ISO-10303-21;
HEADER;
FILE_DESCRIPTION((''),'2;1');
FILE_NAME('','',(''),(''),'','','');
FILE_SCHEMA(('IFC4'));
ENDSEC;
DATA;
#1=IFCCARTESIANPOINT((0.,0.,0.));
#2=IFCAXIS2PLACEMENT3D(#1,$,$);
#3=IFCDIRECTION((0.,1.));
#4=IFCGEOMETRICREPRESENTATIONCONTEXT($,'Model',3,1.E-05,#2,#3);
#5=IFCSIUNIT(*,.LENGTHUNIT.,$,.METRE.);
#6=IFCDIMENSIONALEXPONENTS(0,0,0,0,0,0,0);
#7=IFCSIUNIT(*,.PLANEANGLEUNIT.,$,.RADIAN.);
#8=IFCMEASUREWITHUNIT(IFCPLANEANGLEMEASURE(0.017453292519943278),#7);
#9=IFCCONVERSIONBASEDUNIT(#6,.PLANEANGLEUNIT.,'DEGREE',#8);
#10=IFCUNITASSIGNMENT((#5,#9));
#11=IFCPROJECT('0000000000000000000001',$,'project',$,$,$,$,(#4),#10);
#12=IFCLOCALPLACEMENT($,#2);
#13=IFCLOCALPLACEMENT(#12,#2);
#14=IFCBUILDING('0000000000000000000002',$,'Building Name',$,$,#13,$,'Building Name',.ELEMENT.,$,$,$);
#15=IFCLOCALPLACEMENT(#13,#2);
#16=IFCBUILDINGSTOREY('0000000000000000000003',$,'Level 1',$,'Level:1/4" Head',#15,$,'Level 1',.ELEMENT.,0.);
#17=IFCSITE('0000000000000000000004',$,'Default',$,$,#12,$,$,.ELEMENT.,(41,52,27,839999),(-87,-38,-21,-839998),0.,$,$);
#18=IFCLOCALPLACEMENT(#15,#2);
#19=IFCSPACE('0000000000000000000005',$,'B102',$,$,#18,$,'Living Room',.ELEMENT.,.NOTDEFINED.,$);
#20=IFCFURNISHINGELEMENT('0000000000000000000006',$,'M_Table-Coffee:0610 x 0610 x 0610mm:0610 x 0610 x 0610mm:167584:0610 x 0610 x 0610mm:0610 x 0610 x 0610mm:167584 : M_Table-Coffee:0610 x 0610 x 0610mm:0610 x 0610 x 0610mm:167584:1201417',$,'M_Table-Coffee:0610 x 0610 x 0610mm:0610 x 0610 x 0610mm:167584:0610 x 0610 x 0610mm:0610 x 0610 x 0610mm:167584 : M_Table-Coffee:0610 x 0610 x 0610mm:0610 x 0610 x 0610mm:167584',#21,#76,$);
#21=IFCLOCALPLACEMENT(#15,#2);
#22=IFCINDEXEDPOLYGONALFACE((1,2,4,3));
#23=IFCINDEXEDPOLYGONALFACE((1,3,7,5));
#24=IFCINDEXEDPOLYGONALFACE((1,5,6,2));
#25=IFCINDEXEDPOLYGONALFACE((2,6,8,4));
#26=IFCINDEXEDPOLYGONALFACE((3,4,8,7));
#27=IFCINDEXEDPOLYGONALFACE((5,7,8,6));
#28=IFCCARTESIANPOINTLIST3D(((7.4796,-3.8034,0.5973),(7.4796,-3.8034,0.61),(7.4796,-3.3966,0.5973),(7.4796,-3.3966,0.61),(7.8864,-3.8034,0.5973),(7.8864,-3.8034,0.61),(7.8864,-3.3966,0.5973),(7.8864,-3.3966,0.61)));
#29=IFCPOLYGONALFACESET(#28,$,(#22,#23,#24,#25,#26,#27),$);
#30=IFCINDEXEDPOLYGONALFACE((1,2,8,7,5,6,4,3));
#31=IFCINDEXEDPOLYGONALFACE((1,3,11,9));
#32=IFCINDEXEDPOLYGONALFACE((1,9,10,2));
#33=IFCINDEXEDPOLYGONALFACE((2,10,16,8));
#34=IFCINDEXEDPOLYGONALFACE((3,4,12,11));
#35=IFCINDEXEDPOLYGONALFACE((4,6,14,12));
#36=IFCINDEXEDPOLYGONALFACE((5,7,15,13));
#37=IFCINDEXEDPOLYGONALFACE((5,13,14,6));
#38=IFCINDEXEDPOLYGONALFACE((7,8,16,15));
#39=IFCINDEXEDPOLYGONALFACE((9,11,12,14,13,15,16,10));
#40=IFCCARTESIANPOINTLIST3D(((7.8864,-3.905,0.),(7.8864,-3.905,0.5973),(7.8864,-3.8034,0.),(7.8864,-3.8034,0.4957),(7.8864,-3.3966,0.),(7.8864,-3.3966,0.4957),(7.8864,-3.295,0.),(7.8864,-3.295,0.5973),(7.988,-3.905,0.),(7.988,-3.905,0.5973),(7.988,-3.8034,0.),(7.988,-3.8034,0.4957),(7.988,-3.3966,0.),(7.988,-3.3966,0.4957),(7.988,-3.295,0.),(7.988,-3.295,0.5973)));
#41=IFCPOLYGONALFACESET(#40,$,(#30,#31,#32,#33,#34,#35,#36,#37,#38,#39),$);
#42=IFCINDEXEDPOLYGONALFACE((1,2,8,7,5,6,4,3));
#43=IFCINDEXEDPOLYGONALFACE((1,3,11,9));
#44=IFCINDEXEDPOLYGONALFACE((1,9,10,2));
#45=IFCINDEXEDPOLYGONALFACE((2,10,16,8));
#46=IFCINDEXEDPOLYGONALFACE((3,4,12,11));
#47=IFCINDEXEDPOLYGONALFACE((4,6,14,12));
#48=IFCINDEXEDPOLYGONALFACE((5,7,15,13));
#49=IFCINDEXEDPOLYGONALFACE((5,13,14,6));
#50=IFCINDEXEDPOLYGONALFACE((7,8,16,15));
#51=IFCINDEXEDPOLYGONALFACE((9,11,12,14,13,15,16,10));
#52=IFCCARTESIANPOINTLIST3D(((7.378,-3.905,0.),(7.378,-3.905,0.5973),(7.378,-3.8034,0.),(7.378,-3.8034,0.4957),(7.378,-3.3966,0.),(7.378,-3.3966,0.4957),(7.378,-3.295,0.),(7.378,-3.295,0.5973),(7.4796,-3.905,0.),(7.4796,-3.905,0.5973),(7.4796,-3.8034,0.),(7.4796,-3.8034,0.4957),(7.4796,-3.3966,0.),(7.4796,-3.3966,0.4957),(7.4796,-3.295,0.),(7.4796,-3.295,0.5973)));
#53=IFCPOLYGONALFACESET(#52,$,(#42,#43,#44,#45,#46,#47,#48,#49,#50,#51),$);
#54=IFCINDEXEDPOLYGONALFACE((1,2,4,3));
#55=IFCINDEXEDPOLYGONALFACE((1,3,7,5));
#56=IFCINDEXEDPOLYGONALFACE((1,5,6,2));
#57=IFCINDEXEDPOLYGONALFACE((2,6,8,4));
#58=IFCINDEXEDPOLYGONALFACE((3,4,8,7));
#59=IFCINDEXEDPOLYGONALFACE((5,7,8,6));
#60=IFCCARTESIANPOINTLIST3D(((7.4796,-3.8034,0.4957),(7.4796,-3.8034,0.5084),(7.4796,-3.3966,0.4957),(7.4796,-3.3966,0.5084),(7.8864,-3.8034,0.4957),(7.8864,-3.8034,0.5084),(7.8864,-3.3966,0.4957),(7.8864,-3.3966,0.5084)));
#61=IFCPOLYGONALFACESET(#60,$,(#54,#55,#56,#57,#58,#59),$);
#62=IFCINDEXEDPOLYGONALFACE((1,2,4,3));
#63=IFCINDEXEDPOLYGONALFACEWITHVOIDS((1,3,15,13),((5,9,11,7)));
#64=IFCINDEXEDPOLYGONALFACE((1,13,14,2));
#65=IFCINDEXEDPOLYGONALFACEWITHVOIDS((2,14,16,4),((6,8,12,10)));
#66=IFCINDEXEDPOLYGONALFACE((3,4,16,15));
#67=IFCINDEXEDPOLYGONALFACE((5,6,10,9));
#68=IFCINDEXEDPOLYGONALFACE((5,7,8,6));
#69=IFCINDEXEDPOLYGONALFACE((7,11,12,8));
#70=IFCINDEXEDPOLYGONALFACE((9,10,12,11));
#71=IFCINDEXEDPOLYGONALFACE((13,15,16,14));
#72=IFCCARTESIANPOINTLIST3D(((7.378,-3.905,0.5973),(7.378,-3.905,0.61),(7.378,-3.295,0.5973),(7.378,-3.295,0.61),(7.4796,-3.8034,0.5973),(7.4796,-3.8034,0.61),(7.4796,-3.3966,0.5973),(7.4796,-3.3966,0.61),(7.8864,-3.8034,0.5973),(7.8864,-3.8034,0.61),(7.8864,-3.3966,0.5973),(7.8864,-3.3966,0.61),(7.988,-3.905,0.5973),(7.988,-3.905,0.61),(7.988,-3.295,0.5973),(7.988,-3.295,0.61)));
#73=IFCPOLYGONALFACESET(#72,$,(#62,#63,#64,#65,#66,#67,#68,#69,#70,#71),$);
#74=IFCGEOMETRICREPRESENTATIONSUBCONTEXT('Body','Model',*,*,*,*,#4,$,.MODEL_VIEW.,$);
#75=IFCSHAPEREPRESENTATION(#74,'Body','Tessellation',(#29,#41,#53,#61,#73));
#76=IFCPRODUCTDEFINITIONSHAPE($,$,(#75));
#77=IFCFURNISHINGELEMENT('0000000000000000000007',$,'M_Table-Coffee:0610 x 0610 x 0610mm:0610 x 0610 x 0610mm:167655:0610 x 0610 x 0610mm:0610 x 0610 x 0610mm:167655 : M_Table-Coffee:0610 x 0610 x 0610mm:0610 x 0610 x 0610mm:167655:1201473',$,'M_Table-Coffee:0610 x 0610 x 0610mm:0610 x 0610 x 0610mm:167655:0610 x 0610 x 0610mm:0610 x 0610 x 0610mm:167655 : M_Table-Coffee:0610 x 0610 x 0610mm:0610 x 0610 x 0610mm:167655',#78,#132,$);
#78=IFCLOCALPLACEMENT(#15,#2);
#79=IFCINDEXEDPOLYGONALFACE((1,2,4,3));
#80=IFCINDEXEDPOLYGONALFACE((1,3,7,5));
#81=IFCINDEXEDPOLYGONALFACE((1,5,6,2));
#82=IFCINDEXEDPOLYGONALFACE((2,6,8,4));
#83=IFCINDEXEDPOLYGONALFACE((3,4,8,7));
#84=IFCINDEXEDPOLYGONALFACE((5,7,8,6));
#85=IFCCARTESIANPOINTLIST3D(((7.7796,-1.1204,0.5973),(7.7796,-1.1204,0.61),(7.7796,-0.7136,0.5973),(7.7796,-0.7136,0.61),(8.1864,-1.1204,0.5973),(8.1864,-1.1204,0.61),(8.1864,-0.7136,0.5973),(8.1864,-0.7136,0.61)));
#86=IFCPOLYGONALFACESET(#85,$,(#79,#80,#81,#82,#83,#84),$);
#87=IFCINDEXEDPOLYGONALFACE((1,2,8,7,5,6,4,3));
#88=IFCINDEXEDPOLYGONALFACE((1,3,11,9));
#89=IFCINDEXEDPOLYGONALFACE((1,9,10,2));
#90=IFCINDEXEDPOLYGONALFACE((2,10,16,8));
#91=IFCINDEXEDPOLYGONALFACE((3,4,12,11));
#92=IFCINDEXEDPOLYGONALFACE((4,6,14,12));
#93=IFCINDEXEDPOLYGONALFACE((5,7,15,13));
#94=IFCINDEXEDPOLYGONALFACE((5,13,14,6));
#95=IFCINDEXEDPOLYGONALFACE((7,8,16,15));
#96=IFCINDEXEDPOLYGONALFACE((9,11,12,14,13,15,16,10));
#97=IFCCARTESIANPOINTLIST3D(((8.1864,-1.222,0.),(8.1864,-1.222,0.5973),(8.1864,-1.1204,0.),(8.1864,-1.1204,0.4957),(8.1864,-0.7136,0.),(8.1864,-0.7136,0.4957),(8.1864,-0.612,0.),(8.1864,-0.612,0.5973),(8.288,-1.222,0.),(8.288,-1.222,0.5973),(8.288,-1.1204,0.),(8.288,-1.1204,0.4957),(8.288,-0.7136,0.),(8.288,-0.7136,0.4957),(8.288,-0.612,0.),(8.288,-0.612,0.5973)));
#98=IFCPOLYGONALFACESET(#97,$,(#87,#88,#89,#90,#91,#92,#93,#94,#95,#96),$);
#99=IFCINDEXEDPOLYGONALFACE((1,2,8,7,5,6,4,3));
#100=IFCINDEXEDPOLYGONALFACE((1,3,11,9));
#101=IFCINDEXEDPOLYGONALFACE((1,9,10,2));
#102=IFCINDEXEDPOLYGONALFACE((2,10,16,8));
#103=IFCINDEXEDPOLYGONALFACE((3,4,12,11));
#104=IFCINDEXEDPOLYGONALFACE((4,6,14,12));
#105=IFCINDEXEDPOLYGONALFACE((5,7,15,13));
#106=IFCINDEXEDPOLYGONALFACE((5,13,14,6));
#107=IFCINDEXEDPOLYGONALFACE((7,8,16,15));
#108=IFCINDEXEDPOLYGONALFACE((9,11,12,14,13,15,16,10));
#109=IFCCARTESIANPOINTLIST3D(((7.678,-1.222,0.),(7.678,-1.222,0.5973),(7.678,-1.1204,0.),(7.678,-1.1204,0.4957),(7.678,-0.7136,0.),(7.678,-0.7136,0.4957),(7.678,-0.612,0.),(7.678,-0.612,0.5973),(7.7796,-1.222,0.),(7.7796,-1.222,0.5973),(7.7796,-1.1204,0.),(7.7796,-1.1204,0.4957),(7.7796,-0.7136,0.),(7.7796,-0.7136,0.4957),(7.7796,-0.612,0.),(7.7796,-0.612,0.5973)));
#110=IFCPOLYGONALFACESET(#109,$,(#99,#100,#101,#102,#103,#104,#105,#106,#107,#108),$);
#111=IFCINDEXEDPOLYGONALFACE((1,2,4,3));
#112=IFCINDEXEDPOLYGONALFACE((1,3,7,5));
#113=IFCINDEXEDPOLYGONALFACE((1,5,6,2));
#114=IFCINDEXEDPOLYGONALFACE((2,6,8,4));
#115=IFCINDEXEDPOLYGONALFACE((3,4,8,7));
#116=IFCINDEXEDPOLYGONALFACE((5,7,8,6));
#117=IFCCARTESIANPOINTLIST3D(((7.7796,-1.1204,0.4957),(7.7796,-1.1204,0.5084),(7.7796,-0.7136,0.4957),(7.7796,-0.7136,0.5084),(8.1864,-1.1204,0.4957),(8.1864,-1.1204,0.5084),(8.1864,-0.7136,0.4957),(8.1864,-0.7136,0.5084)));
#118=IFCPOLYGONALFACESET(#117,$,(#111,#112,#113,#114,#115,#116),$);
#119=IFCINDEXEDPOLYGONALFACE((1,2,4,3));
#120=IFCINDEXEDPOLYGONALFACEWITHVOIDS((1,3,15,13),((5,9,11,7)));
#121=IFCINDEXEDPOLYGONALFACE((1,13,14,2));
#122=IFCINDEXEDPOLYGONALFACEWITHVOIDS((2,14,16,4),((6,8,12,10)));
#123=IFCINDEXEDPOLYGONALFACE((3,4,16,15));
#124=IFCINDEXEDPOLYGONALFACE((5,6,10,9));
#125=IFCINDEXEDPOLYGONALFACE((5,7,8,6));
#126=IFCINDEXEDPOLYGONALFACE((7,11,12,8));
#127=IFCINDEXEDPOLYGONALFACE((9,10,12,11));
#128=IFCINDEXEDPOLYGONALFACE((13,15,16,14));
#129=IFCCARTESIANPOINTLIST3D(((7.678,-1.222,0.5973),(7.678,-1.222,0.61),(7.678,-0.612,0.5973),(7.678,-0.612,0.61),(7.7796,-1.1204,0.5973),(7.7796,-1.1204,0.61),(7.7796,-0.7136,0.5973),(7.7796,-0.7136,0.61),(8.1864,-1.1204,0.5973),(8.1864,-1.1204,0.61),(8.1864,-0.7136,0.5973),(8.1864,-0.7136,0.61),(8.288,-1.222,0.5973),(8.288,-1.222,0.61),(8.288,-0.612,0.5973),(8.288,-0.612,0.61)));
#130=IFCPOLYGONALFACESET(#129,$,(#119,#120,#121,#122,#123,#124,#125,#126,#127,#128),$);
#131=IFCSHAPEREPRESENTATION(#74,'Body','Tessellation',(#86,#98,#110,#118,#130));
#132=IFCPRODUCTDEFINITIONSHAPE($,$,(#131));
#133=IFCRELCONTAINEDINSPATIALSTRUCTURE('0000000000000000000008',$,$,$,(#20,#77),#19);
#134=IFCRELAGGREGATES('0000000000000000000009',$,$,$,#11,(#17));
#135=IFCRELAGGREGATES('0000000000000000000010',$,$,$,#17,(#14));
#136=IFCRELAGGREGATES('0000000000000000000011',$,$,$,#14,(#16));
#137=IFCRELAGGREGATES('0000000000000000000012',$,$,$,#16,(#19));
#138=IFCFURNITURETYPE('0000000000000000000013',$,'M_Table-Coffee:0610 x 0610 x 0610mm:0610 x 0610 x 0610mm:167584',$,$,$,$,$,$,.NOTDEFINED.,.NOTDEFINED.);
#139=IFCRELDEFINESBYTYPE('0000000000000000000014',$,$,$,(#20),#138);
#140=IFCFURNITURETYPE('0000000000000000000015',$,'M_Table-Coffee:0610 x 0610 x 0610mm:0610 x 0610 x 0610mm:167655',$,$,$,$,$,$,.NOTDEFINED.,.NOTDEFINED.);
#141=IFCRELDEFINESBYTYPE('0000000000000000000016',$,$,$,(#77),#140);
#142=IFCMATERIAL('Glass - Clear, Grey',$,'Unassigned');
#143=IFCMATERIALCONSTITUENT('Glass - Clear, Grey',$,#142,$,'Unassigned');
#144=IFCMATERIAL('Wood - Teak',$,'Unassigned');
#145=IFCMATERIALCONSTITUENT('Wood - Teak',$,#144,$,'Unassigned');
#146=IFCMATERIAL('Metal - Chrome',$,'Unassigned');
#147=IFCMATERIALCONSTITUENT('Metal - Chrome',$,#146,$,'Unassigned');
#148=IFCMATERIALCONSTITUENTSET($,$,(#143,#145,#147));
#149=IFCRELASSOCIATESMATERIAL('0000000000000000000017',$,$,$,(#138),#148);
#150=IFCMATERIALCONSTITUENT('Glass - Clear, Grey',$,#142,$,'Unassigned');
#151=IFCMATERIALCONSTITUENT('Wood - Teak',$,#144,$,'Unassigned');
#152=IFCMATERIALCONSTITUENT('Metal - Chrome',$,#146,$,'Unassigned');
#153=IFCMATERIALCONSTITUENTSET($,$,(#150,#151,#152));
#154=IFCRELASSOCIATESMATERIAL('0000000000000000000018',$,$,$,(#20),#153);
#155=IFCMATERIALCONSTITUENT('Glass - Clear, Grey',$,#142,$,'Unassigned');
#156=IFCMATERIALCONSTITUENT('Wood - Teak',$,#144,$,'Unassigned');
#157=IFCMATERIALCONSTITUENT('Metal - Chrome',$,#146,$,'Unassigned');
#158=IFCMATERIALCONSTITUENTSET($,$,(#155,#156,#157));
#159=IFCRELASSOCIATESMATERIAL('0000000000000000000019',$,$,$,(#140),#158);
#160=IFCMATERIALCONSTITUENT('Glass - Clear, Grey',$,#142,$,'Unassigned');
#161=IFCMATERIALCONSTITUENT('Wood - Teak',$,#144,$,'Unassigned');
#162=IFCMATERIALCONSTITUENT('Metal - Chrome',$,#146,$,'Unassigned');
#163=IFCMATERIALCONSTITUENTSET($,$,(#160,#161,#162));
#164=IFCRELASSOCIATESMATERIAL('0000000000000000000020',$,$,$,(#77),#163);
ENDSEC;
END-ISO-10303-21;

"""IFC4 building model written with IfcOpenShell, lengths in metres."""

from ifc_helpers import new_model, entity, si_unit, converted_unit, direction, frame, origin, place, context, subcontext, project, spatial, indexed_curve, outline, extrude, source, transform, mapped, material, constituent, constituent_set, type_object, type_shapes, element, save


model = new_model("IFC4")

# Units and contexts
model_context = context("Model", 3, precision=1e-05, world=origin(), true_north=direction((0.0, 1.0)))
body_context = subcontext(model_context, "Body", "Model", "MODEL_VIEW")
ifc_project = project(units=[si_unit("LENGTHUNIT", "METRE"), converted_unit("PLANEANGLEUNIT", "DEGREE", entity("IfcPlaneAngleMeasure", 0.017453292519943278), si_unit("PLANEANGLEUNIT", "RADIAN"), dimensions=[0, 0, 0, 0, 0, 0, 0])], contexts=[model_context])

# Site, building, storey
site_placement = place(None, origin())
site = spatial("IfcSite", under=ifc_project, at=site_placement, Name="Default", CompositionType="ELEMENT", RefLatitude=(41, 52, 27, 839999), RefLongitude=(-87, -38, -21, -839998), RefElevation=0.0)
building_placement = place(site_placement, origin())
building = spatial("IfcBuilding", under=site, at=building_placement, Name="Building Name", LongName="Building Name", CompositionType="ELEMENT")
storey_placement = place(building_placement, origin())
storey = spatial("IfcBuildingStorey", under=building, at=storey_placement, Name="Level 1", ObjectType="Level:1/4\" Head", LongName="Level 1", CompositionType="ELEMENT", Elevation=0.0)

# Shared definitions
space_1_placement = place(storey_placement, origin())
space_1 = spatial("IfcSpace", under=storey, at=space_1_placement, Name="B102", LongName="Living Room", CompositionType="ELEMENT", PredefinedType="NOTDEFINED")

# Furnishing elements
ifc_material_1 = material(Name="Glass - Clear, Grey", Category="Unassigned")
ifc_constituent_1 = constituent(ifc_material_1, Name="Glass - Clear, Grey", Category="Unassigned")
ifc_material_2 = material(Name="Wood - Teak", Category="Unassigned")
ifc_constituent_2 = constituent(ifc_material_2, Name="Wood - Teak", Category="Unassigned")
ifc_material_3 = material(Name="Metal - Chrome", Category="Unassigned")
ifc_constituent_3 = constituent(ifc_material_3, Name="Metal - Chrome", Category="Unassigned")
ifc_constituent_set_1 = constituent_set(constituents=[ifc_constituent_1, ifc_constituent_2, ifc_constituent_3])
ifc_constituent_4 = constituent(ifc_material_1, Name="Glass - Clear, Grey", Category="Unassigned")
ifc_constituent_5 = constituent(ifc_material_2, Name="Wood - Teak", Category="Unassigned")
ifc_constituent_6 = constituent(ifc_material_3, Name="Metal - Chrome", Category="Unassigned")
ifc_constituent_set_2 = constituent_set(constituents=[ifc_constituent_4, ifc_constituent_5, ifc_constituent_6])
furniture_type_1 = type_object("IfcFurnitureType", Name="M_Table-Coffee:0610 x 0610 x 0610mm:0610 x 0610 x 0610mm:167584", AssemblyPlace="NOTDEFINED", PredefinedType="NOTDEFINED", material=ifc_constituent_set_2)
shared_shape_1 = source(origin(), body_context, "Body", "SweptSolid", [
    extrude(outline(indexed_curve([(-0.2034, -0.2034), (0.2034, -0.2034), (0.2034, 0.2034), (-0.2034, 0.2034), (-0.2034, -0.2034)], self_intersect=False)), frame((7.683, -3.6, 0.5973), z_axis=(0.0, 0.0, 1.0), x_axis=(0.0, -1.0, 0.0)), (0.0, 0.0, 1.0), 0.0127),
    extrude(outline(indexed_curve([(-0.305, -0.324), (0.305, -0.324), (0.305, 0.2732), (0.2034, 0.2732), (0.2034, -0.2225), (-0.2034, -0.2225), (-0.2034, 0.2732), (-0.305, 0.2732), (-0.305, -0.324)], self_intersect=False)), frame((7.8864, -3.6, 0.2732), z_axis=(1.0, 0.0, 0.0), x_axis=(0.0, -1.0, 0.0)), (0.0, 0.0, 1.0), 0.1016),
    extrude(outline(indexed_curve([(-0.3241, -0.305), (0.2733, -0.305), (0.2733, -0.2034), (-0.2224, -0.2034), (-0.2224, 0.2034), (0.2733, 0.2034), (0.2733, 0.305), (-0.3241, 0.305), (-0.3241, -0.305)], self_intersect=False)), frame((7.378, -3.6, 0.2733), z_axis=(1.0, 0.0, 0.0), x_axis=(0.0, 0.0, -1.0)), (0.0, 0.0, 1.0), 0.1016),
    extrude(outline(indexed_curve([(-0.2034, -0.2034), (0.2034, -0.2034), (0.2034, 0.2034), (-0.2034, 0.2034), (-0.2034, -0.2034)], self_intersect=False)), frame((7.683, -3.6, 0.4957), z_axis=(0.0, 0.0, 1.0), x_axis=(0.0, -1.0, 0.0)), (0.0, 0.0, 1.0), 0.0127),
    extrude(outline(indexed_curve([(-0.305, -0.305), (0.305, -0.305), (0.305, 0.305), (-0.305, 0.305), (-0.305, -0.305)], self_intersect=False), holes=[indexed_curve([(0.2034, 0.2034), (0.2034, -0.2034), (-0.2034, -0.2034), (-0.2034, 0.2034), (0.2034, 0.2034)], self_intersect=False)]), frame((7.683, -3.6, 0.5973), z_axis=(0.0, 0.0, 1.0), x_axis=(0.0, -1.0, 0.0)), (0.0, 0.0, 1.0), 0.0127),
])
type_shapes(furniture_type_1, [shared_shape_1])
furnishing_1_placement = place(space_1_placement, origin())
element("IfcFurnishingElement", 1, at=furnishing_1_placement, inside=space_1, type_object=furniture_type_1, material=ifc_constituent_set_1, Name="M_Table-Coffee:0610 x 0610 x 0610mm:0610 x 0610 x 0610mm:167584:0610 x 0610 x 0610mm:0610 x 0610 x 0610mm:167584 : M_Table-Coffee:0610 x 0610 x 0610mm:0610 x 0610 x 0610mm:167584:1201417", ObjectType="M_Table-Coffee:0610 x 0610 x 0610mm:0610 x 0610 x 0610mm:167584:0610 x 0610 x 0610mm:0610 x 0610 x 0610mm:167584 : M_Table-Coffee:0610 x 0610 x 0610mm:0610 x 0610 x 0610mm:167584", context=body_context, shape_type="MappedRepresentation", body=[
    mapped(shared_shape_1, transform((0.0, 0.0, 0.0), scale=1.0)),
])
ifc_constituent_7 = constituent(ifc_material_1, Name="Glass - Clear, Grey", Category="Unassigned")
ifc_constituent_8 = constituent(ifc_material_2, Name="Wood - Teak", Category="Unassigned")
ifc_constituent_9 = constituent(ifc_material_3, Name="Metal - Chrome", Category="Unassigned")
ifc_constituent_set_3 = constituent_set(constituents=[ifc_constituent_7, ifc_constituent_8, ifc_constituent_9])
ifc_constituent_10 = constituent(ifc_material_1, Name="Glass - Clear, Grey", Category="Unassigned")
ifc_constituent_11 = constituent(ifc_material_2, Name="Wood - Teak", Category="Unassigned")
ifc_constituent_12 = constituent(ifc_material_3, Name="Metal - Chrome", Category="Unassigned")
ifc_constituent_set_4 = constituent_set(constituents=[ifc_constituent_10, ifc_constituent_11, ifc_constituent_12])
furniture_type_2 = type_object("IfcFurnitureType", Name="M_Table-Coffee:0610 x 0610 x 0610mm:0610 x 0610 x 0610mm:167655", AssemblyPlace="NOTDEFINED", PredefinedType="NOTDEFINED", material=ifc_constituent_set_4)
shared_shape_2 = source(origin(), body_context, "Body", "SweptSolid", [
    extrude(outline(indexed_curve([(-0.2034, -0.2034), (0.2034, -0.2034), (0.2034, 0.2034), (-0.2034, 0.2034), (-0.2034, -0.2034)], self_intersect=False)), frame((7.983, -0.917, 0.5973), z_axis=(0.0, 0.0, 1.0), x_axis=(0.0, -1.0, 0.0)), (0.0, 0.0, 1.0), 0.0127),
    extrude(outline(indexed_curve([(-0.305, -0.324), (0.305, -0.324), (0.305, 0.2732), (0.2034, 0.2732), (0.2034, -0.2225), (-0.2034, -0.2225), (-0.2034, 0.2732), (-0.305, 0.2732), (-0.305, -0.324)], self_intersect=False)), frame((8.1864, -0.917, 0.2732), z_axis=(1.0, 0.0, 0.0), x_axis=(0.0, -1.0, 0.0)), (0.0, 0.0, 1.0), 0.1016),
    extrude(outline(indexed_curve([(-0.3241, -0.305), (0.2733, -0.305), (0.2733, -0.2034), (-0.2224, -0.2034), (-0.2224, 0.2034), (0.2733, 0.2034), (0.2733, 0.305), (-0.3241, 0.305), (-0.3241, -0.305)], self_intersect=False)), frame((7.678, -0.917, 0.2733), z_axis=(1.0, 0.0, 0.0), x_axis=(0.0, 0.0, -1.0)), (0.0, 0.0, 1.0), 0.1016),
    extrude(outline(indexed_curve([(-0.2034, -0.2034), (0.2034, -0.2034), (0.2034, 0.2034), (-0.2034, 0.2034), (-0.2034, -0.2034)], self_intersect=False)), frame((7.983, -0.917, 0.4957), z_axis=(0.0, 0.0, 1.0), x_axis=(0.0, -1.0, 0.0)), (0.0, 0.0, 1.0), 0.0127),
    extrude(outline(indexed_curve([(-0.305, -0.305), (0.305, -0.305), (0.305, 0.305), (-0.305, 0.305), (-0.305, -0.305)], self_intersect=False), holes=[indexed_curve([(0.2034, 0.2034), (0.2034, -0.2034), (-0.2034, -0.2034), (-0.2034, 0.2034), (0.2034, 0.2034)], self_intersect=False)]), frame((7.983, -0.917, 0.5973), z_axis=(0.0, 0.0, 1.0), x_axis=(0.0, -1.0, 0.0)), (0.0, 0.0, 1.0), 0.0127),
])
type_shapes(furniture_type_2, [shared_shape_2])
furnishing_2_placement = place(space_1_placement, origin())
element("IfcFurnishingElement", 2, at=furnishing_2_placement, inside=space_1, type_object=furniture_type_2, material=ifc_constituent_set_3, Name="M_Table-Coffee:0610 x 0610 x 0610mm:0610 x 0610 x 0610mm:167655:0610 x 0610 x 0610mm:0610 x 0610 x 0610mm:167655 : M_Table-Coffee:0610 x 0610 x 0610mm:0610 x 0610 x 0610mm:167655:1201473", ObjectType="M_Table-Coffee:0610 x 0610 x 0610mm:0610 x 0610 x 0610mm:167655:0610 x 0610 x 0610mm:0610 x 0610 x 0610mm:167655 : M_Table-Coffee:0610 x 0610 x 0610mm:0610 x 0610 x 0610mm:167655", context=body_context, shape_type="MappedRepresentation", body=[
    mapped(shared_shape_2, transform((0.0, 0.0, 0.0), scale=1.0)),
])

save(model, "model.ifc")
